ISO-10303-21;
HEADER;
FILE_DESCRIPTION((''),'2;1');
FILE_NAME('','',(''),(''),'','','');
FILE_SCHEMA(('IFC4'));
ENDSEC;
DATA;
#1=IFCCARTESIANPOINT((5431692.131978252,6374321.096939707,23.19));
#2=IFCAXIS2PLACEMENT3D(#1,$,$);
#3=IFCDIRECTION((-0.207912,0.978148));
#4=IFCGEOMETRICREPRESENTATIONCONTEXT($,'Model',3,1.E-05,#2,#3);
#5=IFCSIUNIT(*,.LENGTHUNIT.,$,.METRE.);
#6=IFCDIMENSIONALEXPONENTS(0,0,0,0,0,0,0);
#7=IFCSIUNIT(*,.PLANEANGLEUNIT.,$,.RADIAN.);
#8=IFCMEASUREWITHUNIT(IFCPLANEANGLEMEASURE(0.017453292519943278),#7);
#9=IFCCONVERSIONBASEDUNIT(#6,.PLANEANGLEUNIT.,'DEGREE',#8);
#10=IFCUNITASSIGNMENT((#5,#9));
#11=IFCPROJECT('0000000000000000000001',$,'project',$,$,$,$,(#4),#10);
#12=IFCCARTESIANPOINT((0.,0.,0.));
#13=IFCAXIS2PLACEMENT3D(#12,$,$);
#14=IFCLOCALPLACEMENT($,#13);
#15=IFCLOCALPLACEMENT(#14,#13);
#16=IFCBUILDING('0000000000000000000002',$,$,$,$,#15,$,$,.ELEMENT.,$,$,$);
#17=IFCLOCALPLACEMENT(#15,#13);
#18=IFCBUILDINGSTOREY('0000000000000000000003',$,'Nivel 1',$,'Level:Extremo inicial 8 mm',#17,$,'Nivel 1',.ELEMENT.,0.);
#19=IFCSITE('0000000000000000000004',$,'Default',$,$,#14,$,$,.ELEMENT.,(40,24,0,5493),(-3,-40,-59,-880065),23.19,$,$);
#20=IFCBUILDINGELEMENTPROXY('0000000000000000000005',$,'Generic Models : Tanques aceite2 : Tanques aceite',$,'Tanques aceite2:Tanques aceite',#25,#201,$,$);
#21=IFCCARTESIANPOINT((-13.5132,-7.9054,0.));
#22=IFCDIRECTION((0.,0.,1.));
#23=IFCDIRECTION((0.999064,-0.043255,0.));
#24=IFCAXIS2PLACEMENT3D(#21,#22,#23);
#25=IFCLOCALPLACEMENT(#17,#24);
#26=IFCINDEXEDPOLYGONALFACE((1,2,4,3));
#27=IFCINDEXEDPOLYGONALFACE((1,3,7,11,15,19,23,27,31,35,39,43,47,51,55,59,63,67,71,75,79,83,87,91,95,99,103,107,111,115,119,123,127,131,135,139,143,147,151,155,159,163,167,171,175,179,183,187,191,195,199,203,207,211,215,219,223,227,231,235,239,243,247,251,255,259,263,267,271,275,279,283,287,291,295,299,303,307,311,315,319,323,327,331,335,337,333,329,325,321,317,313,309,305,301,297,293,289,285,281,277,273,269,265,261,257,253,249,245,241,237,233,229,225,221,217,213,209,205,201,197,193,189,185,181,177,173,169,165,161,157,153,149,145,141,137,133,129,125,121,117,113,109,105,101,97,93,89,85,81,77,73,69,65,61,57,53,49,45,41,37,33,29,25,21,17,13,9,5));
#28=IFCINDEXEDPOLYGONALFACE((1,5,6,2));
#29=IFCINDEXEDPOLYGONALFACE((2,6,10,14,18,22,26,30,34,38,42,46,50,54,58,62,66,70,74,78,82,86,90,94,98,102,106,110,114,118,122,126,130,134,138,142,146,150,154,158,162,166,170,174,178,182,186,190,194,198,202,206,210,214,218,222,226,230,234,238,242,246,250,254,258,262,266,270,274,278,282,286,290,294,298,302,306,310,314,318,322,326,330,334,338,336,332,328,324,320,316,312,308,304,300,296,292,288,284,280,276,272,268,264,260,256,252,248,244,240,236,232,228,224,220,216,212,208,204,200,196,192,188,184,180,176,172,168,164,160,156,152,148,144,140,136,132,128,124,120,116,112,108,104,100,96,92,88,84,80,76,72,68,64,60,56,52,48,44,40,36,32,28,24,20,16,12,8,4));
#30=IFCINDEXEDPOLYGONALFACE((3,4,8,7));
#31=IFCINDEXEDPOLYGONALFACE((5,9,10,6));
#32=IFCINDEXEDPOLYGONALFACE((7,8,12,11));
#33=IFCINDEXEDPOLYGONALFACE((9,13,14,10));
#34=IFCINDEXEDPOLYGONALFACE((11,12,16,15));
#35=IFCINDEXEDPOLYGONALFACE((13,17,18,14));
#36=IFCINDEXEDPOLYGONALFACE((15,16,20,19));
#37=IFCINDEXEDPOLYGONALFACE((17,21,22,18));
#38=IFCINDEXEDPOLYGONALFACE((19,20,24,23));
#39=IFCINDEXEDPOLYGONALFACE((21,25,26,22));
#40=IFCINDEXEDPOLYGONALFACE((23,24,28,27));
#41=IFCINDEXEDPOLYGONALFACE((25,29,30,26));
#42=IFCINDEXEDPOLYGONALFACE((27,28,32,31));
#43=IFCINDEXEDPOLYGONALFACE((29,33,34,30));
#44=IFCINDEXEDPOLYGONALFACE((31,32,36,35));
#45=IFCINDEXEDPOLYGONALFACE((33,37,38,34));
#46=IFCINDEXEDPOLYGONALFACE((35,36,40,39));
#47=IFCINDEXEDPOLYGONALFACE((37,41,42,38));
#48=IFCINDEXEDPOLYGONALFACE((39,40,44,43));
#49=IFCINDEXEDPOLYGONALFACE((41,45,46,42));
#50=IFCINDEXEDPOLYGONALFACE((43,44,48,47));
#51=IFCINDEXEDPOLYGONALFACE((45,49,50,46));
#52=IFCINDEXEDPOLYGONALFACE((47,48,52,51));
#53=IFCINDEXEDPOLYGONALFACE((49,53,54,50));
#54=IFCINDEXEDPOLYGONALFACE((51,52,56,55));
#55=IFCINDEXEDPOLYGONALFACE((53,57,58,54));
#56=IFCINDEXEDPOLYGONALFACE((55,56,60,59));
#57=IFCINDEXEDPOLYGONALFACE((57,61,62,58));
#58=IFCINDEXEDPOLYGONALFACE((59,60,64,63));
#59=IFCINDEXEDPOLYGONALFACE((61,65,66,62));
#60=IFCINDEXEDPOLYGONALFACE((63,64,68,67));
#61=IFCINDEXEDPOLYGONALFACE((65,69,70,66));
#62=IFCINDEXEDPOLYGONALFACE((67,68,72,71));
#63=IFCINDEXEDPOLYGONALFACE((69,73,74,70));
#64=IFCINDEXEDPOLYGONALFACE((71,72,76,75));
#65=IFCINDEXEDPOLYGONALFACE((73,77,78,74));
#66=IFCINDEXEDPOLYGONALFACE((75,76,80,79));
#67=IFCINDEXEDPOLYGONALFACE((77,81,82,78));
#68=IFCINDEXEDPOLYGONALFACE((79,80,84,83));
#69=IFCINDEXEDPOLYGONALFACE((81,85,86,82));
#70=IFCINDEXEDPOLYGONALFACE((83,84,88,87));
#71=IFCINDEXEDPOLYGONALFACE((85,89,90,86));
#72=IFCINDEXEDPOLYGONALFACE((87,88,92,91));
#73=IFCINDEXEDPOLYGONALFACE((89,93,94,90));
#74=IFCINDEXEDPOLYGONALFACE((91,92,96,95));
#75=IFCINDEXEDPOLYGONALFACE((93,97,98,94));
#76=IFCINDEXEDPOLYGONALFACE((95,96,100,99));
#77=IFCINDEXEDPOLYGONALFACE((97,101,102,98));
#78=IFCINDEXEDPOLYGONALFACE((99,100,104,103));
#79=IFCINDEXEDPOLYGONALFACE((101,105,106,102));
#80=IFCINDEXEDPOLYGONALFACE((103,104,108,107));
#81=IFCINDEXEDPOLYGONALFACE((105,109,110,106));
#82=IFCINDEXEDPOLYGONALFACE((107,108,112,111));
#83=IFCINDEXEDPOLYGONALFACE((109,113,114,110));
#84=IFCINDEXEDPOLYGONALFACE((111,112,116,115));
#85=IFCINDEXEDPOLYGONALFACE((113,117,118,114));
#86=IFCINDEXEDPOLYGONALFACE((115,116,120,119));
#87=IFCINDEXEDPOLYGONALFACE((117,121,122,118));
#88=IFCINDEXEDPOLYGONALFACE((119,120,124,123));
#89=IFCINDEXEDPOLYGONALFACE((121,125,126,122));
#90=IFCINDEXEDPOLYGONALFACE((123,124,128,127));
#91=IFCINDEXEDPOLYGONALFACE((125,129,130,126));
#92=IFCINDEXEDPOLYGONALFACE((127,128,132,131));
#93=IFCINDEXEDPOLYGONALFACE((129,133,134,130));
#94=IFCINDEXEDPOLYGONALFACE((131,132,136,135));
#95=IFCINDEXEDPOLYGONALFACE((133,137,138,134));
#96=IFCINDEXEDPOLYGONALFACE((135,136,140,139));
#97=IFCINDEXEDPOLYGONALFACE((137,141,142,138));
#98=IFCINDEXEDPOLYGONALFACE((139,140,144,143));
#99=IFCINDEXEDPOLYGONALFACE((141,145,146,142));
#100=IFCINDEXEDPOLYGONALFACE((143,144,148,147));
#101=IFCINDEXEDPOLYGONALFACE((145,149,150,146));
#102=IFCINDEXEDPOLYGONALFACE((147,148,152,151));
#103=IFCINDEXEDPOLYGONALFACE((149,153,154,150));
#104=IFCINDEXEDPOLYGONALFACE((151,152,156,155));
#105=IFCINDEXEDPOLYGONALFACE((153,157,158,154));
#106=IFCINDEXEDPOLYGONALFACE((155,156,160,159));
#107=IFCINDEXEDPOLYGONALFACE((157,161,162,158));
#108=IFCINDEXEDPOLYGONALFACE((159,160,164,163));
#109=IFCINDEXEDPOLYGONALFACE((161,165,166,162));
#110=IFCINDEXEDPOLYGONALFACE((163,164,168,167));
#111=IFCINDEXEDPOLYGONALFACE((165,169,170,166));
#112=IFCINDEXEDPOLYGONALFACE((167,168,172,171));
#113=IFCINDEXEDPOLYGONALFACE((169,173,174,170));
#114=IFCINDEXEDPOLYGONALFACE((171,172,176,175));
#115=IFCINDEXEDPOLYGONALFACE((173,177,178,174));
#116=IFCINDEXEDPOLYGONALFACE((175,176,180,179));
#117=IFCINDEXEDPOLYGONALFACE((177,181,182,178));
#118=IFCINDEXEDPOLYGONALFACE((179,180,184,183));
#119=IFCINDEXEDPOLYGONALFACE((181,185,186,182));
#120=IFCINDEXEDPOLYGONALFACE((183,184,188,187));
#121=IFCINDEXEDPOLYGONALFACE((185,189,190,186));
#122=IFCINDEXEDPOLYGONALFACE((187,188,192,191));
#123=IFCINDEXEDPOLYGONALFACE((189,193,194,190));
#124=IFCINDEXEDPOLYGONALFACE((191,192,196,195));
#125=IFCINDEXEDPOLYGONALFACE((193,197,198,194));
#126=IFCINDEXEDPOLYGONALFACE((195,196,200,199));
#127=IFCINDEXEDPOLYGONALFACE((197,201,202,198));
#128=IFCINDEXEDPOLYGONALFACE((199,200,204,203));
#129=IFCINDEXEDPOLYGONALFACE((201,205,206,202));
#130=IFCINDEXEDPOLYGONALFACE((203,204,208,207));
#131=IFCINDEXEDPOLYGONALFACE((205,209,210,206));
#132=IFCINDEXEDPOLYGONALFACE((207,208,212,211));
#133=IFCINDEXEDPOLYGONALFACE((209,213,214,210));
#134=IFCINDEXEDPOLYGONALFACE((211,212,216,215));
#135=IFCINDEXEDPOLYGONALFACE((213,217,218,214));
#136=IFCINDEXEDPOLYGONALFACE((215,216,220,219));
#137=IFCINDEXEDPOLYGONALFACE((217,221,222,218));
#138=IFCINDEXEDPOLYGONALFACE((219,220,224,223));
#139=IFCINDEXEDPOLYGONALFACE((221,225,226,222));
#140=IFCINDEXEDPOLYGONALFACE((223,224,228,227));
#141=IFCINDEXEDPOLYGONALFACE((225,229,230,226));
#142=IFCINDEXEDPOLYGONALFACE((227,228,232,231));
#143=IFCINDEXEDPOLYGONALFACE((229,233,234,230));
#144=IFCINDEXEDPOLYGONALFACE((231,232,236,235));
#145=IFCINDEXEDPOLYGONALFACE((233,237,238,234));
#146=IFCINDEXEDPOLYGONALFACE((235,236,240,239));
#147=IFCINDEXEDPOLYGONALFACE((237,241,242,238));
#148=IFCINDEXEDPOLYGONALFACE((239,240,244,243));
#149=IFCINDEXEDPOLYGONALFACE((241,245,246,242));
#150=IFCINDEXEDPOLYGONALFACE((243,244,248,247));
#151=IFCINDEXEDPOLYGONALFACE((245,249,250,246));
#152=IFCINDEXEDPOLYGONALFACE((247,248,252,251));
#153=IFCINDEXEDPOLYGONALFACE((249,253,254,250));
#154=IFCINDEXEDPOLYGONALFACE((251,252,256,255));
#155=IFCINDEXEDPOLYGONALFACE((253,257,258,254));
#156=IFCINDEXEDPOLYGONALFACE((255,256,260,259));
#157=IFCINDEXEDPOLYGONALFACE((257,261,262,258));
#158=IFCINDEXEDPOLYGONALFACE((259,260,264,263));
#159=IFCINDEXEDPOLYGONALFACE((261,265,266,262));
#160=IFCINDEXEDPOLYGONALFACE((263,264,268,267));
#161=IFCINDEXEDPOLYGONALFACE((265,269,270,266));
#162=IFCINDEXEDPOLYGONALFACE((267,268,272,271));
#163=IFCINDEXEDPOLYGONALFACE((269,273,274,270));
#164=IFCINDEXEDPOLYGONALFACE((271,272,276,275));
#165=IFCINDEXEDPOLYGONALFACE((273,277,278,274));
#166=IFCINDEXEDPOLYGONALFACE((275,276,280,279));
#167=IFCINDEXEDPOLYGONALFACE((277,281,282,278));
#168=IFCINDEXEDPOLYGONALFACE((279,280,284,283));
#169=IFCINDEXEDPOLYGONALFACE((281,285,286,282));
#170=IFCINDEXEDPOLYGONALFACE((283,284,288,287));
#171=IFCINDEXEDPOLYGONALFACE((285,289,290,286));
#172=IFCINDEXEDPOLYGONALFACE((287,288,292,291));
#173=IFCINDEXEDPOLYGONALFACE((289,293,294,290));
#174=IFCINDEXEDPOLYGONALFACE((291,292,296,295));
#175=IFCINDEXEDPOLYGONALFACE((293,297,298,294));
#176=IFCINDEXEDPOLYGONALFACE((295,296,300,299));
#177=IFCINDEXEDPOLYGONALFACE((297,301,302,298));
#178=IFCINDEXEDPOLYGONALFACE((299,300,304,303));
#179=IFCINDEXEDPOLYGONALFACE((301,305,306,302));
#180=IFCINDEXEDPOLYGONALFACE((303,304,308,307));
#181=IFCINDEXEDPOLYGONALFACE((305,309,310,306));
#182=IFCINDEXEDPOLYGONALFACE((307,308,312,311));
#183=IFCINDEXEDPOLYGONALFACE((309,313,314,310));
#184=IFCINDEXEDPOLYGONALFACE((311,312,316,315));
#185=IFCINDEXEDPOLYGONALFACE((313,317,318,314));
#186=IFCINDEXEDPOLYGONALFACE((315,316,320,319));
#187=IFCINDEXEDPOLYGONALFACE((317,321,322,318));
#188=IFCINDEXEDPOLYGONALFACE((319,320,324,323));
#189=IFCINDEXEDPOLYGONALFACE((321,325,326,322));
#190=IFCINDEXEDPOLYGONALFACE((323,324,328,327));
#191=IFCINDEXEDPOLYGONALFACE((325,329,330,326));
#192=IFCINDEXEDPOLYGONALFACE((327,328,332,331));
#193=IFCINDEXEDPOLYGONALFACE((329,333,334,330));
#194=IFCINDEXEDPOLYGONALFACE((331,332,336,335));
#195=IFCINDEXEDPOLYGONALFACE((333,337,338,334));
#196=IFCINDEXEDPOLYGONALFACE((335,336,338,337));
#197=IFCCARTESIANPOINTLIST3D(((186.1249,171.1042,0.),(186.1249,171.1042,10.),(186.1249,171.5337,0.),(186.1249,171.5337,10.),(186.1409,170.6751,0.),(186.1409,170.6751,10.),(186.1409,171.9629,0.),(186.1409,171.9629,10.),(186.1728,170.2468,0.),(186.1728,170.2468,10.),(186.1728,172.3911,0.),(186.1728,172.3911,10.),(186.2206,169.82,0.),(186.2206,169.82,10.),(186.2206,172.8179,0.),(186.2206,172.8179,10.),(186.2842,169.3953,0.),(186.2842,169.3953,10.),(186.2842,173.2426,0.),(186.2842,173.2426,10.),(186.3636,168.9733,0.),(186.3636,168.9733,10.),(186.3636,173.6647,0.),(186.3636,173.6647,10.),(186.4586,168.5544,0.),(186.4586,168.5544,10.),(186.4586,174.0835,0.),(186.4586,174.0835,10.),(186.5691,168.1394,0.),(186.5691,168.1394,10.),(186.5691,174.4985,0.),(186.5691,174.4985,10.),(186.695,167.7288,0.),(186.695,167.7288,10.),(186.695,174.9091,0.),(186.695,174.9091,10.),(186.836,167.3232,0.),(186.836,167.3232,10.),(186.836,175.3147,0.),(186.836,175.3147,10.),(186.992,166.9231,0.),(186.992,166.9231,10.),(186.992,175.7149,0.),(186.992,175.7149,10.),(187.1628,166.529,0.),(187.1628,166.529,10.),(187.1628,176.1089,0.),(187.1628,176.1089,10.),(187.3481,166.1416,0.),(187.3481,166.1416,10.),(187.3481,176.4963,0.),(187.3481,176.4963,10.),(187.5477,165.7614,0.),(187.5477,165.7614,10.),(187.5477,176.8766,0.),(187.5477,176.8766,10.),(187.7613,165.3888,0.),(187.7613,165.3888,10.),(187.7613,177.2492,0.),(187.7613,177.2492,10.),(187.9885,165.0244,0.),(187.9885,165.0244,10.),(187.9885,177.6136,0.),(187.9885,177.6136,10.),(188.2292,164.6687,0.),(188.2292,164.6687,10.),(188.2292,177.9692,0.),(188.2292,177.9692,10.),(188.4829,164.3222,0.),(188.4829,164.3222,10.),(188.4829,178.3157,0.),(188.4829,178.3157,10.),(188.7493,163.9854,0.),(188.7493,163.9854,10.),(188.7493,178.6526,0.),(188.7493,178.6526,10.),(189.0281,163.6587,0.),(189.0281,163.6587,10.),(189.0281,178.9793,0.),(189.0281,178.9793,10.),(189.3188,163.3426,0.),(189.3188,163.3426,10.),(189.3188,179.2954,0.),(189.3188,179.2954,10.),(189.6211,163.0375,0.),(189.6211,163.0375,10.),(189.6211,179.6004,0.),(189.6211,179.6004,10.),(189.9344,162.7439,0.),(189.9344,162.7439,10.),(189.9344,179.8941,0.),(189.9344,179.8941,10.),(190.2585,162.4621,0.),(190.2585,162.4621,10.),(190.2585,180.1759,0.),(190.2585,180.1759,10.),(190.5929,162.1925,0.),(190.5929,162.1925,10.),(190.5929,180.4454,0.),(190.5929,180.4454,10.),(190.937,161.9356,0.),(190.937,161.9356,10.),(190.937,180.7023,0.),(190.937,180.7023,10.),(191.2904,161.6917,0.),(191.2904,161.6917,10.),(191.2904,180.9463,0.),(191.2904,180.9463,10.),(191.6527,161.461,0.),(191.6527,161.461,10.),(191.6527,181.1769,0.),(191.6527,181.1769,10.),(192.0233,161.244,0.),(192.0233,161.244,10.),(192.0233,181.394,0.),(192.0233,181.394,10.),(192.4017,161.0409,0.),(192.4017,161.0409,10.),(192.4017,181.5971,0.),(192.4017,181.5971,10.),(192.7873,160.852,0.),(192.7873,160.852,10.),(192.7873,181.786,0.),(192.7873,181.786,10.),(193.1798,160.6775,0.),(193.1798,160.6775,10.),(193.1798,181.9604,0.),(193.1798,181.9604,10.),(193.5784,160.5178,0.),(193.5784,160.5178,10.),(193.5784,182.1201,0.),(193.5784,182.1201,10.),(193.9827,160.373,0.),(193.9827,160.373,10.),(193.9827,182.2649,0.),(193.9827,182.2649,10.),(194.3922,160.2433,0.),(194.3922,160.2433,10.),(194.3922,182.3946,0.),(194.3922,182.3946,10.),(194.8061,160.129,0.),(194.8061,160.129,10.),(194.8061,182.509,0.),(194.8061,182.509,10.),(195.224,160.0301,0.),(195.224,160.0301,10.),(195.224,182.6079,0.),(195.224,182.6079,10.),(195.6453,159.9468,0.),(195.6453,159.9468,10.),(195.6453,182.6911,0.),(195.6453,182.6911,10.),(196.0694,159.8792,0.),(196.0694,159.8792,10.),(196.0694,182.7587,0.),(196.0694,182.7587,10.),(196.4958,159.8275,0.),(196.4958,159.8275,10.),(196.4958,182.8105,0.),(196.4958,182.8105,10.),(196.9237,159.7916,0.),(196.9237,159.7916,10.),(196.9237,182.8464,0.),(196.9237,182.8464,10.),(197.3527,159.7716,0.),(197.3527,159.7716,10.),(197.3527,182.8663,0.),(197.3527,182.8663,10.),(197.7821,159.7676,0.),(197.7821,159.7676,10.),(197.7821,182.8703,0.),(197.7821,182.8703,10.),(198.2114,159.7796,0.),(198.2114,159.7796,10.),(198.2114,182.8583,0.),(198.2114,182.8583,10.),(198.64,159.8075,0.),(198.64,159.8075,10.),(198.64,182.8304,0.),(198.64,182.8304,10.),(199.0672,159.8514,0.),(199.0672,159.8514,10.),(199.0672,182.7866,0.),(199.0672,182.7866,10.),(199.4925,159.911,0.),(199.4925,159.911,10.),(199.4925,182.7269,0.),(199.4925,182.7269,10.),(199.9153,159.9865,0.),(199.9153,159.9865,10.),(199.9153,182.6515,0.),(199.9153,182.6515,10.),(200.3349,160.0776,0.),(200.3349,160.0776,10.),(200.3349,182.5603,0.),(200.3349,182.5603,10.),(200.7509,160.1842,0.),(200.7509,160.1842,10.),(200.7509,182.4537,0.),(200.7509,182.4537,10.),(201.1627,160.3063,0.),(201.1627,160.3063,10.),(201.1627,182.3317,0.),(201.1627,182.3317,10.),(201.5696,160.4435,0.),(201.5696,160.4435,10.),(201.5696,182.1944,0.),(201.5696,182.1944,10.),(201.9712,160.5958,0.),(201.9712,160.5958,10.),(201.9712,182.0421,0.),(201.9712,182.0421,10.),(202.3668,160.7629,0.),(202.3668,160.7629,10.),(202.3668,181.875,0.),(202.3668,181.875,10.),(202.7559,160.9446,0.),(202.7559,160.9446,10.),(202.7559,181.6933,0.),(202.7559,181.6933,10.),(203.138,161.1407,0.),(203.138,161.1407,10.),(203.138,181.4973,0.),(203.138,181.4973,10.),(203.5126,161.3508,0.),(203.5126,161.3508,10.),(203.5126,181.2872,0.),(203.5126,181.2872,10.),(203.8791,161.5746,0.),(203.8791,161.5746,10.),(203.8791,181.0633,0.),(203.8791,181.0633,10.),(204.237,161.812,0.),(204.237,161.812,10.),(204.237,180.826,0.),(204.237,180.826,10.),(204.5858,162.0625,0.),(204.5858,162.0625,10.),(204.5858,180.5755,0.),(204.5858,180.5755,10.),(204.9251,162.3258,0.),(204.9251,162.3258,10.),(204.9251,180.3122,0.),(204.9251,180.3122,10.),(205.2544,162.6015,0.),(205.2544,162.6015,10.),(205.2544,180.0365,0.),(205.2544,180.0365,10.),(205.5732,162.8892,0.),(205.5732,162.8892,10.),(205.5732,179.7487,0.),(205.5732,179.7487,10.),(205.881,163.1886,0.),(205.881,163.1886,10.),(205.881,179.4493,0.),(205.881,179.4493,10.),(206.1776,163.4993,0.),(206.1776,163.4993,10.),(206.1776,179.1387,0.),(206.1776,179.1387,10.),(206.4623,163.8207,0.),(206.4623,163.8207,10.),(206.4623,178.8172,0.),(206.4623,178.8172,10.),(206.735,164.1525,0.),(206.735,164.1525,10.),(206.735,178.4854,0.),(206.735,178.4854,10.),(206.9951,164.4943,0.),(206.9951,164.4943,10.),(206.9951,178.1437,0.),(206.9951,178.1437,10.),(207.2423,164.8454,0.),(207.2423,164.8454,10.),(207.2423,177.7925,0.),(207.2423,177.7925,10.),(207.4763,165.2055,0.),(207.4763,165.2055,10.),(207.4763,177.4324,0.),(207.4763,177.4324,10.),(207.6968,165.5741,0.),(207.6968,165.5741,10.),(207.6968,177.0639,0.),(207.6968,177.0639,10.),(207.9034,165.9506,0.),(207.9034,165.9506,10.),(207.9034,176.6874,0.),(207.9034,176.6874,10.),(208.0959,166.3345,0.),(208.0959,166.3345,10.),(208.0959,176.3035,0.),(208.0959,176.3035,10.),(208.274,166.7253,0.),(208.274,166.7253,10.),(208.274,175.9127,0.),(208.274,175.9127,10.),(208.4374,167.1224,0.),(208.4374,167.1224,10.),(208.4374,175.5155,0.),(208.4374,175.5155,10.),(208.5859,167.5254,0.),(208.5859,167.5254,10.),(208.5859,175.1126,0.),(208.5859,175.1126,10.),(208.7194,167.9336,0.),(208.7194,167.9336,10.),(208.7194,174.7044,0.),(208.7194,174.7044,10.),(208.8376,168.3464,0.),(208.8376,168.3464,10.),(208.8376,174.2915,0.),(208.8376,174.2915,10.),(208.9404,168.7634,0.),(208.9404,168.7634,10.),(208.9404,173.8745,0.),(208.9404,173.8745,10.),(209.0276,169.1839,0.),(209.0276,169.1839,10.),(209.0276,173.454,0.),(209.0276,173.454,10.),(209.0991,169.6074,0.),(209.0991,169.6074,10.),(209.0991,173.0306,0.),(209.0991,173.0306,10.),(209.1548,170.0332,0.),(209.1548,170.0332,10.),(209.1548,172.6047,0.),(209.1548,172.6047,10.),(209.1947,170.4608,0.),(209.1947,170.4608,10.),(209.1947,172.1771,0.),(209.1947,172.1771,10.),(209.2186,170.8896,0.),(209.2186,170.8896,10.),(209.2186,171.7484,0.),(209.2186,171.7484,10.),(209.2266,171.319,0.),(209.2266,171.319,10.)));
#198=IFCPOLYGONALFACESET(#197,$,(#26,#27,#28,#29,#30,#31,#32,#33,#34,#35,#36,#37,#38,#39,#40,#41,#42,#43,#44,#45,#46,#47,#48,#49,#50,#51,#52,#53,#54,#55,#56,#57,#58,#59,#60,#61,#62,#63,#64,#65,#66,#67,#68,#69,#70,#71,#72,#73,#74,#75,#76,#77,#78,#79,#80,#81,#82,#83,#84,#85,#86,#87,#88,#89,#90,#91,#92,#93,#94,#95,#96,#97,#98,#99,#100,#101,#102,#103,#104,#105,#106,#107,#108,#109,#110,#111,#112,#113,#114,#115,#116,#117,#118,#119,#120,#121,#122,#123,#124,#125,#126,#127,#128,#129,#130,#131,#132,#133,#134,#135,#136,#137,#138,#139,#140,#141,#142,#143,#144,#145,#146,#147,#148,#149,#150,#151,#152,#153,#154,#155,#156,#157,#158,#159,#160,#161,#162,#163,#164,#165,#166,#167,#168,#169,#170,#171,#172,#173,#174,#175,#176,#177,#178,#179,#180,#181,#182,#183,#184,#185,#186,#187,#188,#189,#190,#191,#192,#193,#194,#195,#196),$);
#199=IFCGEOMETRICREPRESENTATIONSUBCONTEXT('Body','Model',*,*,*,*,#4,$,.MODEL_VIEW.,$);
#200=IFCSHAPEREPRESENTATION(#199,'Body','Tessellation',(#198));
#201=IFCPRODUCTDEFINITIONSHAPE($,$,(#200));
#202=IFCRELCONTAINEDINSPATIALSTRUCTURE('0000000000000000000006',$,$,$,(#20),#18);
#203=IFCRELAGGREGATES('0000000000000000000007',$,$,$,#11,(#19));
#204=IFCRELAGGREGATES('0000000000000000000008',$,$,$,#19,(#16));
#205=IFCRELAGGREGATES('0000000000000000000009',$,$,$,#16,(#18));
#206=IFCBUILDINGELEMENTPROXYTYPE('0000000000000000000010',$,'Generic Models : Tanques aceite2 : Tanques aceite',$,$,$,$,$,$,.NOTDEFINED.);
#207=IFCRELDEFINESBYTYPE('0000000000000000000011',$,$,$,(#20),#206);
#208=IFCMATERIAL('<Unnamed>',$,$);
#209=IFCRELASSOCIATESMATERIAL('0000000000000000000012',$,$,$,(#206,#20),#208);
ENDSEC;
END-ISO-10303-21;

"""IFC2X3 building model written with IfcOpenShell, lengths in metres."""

from ifc_helpers import new_model, entity, si_unit, converted_unit, direction, frame, origin, origin_2d_with_axis, place, context, subcontext, project, spatial, circle, extrude, source, transform, mapped, material, type_object, type_shapes, element, save


model = new_model("IFC2X3")

# Units and contexts
model_context = context("Model", 3, precision=1e-05, world=frame((5431692.131978252, 6374321.096939707, 23.19)), true_north=direction((-0.207912, 0.978148)))
body_context = subcontext(model_context, "Body", "Model", "MODEL_VIEW")
ifc_project = project(units=[si_unit("LENGTHUNIT", "METRE"), converted_unit("PLANEANGLEUNIT", "DEGREE", entity("IfcPlaneAngleMeasure", 0.017453292519943278), si_unit("PLANEANGLEUNIT", "RADIAN"), dimensions=[0, 0, 0, 0, 0, 0, 0])], contexts=[model_context])

# Site, building, storey
site_placement = place(None, origin())
site = spatial("IfcSite", under=ifc_project, at=site_placement, Name="Default", CompositionType="ELEMENT", RefLatitude=(40, 24, 0, 5493), RefLongitude=(-3, -40, -59, -880065), RefElevation=23.19)
building_placement = place(site_placement, origin())
building = spatial("IfcBuilding", under=site, at=building_placement, CompositionType="ELEMENT")
storey_placement = place(building_placement, origin())
storey = spatial("IfcBuildingStorey", under=building, at=storey_placement, Name="Nivel 1", ObjectType="Level:Extremo inicial 8 mm", LongName="Nivel 1", CompositionType="ELEMENT", Elevation=0.0)

# Building element proxy
ifc_material_1 = material(Name="<Unnamed>")
building_element_proxy_type_1 = type_object("IfcBuildingElementProxyType", Name="Generic Models : Tanques aceite2 : Tanques aceite", PredefinedType="NOTDEFINED", material=ifc_material_1)
shared_shape_1 = source(origin(), body_context, "Body", "SweptSolid", [
    extrude(circle(Radius=11.5518, at=origin_2d_with_axis()), frame((197.6748, 171.319, 0.0)), (0.0, 0.0, 1.0), 10.0),
])
type_shapes(building_element_proxy_type_1, [shared_shape_1])
proxy_1_placement = place(storey_placement, frame((-13.5132, -7.9054, 0.0), z_axis=(0.0, 0.0, 1.0), x_axis=(0.999064, -0.043255, 0.0)))
element("IfcBuildingElementProxy", 1, at=proxy_1_placement, inside=storey, type_object=building_element_proxy_type_1, material=ifc_material_1, Name="Generic Models : Tanques aceite2 : Tanques aceite", ObjectType="Tanques aceite2:Tanques aceite", context=body_context, shape_type="MappedRepresentation", body=[
    mapped(shared_shape_1, transform((0.0, 0.0, 0.0), scale=1.0)),
])

save(model, "model.ifc")
